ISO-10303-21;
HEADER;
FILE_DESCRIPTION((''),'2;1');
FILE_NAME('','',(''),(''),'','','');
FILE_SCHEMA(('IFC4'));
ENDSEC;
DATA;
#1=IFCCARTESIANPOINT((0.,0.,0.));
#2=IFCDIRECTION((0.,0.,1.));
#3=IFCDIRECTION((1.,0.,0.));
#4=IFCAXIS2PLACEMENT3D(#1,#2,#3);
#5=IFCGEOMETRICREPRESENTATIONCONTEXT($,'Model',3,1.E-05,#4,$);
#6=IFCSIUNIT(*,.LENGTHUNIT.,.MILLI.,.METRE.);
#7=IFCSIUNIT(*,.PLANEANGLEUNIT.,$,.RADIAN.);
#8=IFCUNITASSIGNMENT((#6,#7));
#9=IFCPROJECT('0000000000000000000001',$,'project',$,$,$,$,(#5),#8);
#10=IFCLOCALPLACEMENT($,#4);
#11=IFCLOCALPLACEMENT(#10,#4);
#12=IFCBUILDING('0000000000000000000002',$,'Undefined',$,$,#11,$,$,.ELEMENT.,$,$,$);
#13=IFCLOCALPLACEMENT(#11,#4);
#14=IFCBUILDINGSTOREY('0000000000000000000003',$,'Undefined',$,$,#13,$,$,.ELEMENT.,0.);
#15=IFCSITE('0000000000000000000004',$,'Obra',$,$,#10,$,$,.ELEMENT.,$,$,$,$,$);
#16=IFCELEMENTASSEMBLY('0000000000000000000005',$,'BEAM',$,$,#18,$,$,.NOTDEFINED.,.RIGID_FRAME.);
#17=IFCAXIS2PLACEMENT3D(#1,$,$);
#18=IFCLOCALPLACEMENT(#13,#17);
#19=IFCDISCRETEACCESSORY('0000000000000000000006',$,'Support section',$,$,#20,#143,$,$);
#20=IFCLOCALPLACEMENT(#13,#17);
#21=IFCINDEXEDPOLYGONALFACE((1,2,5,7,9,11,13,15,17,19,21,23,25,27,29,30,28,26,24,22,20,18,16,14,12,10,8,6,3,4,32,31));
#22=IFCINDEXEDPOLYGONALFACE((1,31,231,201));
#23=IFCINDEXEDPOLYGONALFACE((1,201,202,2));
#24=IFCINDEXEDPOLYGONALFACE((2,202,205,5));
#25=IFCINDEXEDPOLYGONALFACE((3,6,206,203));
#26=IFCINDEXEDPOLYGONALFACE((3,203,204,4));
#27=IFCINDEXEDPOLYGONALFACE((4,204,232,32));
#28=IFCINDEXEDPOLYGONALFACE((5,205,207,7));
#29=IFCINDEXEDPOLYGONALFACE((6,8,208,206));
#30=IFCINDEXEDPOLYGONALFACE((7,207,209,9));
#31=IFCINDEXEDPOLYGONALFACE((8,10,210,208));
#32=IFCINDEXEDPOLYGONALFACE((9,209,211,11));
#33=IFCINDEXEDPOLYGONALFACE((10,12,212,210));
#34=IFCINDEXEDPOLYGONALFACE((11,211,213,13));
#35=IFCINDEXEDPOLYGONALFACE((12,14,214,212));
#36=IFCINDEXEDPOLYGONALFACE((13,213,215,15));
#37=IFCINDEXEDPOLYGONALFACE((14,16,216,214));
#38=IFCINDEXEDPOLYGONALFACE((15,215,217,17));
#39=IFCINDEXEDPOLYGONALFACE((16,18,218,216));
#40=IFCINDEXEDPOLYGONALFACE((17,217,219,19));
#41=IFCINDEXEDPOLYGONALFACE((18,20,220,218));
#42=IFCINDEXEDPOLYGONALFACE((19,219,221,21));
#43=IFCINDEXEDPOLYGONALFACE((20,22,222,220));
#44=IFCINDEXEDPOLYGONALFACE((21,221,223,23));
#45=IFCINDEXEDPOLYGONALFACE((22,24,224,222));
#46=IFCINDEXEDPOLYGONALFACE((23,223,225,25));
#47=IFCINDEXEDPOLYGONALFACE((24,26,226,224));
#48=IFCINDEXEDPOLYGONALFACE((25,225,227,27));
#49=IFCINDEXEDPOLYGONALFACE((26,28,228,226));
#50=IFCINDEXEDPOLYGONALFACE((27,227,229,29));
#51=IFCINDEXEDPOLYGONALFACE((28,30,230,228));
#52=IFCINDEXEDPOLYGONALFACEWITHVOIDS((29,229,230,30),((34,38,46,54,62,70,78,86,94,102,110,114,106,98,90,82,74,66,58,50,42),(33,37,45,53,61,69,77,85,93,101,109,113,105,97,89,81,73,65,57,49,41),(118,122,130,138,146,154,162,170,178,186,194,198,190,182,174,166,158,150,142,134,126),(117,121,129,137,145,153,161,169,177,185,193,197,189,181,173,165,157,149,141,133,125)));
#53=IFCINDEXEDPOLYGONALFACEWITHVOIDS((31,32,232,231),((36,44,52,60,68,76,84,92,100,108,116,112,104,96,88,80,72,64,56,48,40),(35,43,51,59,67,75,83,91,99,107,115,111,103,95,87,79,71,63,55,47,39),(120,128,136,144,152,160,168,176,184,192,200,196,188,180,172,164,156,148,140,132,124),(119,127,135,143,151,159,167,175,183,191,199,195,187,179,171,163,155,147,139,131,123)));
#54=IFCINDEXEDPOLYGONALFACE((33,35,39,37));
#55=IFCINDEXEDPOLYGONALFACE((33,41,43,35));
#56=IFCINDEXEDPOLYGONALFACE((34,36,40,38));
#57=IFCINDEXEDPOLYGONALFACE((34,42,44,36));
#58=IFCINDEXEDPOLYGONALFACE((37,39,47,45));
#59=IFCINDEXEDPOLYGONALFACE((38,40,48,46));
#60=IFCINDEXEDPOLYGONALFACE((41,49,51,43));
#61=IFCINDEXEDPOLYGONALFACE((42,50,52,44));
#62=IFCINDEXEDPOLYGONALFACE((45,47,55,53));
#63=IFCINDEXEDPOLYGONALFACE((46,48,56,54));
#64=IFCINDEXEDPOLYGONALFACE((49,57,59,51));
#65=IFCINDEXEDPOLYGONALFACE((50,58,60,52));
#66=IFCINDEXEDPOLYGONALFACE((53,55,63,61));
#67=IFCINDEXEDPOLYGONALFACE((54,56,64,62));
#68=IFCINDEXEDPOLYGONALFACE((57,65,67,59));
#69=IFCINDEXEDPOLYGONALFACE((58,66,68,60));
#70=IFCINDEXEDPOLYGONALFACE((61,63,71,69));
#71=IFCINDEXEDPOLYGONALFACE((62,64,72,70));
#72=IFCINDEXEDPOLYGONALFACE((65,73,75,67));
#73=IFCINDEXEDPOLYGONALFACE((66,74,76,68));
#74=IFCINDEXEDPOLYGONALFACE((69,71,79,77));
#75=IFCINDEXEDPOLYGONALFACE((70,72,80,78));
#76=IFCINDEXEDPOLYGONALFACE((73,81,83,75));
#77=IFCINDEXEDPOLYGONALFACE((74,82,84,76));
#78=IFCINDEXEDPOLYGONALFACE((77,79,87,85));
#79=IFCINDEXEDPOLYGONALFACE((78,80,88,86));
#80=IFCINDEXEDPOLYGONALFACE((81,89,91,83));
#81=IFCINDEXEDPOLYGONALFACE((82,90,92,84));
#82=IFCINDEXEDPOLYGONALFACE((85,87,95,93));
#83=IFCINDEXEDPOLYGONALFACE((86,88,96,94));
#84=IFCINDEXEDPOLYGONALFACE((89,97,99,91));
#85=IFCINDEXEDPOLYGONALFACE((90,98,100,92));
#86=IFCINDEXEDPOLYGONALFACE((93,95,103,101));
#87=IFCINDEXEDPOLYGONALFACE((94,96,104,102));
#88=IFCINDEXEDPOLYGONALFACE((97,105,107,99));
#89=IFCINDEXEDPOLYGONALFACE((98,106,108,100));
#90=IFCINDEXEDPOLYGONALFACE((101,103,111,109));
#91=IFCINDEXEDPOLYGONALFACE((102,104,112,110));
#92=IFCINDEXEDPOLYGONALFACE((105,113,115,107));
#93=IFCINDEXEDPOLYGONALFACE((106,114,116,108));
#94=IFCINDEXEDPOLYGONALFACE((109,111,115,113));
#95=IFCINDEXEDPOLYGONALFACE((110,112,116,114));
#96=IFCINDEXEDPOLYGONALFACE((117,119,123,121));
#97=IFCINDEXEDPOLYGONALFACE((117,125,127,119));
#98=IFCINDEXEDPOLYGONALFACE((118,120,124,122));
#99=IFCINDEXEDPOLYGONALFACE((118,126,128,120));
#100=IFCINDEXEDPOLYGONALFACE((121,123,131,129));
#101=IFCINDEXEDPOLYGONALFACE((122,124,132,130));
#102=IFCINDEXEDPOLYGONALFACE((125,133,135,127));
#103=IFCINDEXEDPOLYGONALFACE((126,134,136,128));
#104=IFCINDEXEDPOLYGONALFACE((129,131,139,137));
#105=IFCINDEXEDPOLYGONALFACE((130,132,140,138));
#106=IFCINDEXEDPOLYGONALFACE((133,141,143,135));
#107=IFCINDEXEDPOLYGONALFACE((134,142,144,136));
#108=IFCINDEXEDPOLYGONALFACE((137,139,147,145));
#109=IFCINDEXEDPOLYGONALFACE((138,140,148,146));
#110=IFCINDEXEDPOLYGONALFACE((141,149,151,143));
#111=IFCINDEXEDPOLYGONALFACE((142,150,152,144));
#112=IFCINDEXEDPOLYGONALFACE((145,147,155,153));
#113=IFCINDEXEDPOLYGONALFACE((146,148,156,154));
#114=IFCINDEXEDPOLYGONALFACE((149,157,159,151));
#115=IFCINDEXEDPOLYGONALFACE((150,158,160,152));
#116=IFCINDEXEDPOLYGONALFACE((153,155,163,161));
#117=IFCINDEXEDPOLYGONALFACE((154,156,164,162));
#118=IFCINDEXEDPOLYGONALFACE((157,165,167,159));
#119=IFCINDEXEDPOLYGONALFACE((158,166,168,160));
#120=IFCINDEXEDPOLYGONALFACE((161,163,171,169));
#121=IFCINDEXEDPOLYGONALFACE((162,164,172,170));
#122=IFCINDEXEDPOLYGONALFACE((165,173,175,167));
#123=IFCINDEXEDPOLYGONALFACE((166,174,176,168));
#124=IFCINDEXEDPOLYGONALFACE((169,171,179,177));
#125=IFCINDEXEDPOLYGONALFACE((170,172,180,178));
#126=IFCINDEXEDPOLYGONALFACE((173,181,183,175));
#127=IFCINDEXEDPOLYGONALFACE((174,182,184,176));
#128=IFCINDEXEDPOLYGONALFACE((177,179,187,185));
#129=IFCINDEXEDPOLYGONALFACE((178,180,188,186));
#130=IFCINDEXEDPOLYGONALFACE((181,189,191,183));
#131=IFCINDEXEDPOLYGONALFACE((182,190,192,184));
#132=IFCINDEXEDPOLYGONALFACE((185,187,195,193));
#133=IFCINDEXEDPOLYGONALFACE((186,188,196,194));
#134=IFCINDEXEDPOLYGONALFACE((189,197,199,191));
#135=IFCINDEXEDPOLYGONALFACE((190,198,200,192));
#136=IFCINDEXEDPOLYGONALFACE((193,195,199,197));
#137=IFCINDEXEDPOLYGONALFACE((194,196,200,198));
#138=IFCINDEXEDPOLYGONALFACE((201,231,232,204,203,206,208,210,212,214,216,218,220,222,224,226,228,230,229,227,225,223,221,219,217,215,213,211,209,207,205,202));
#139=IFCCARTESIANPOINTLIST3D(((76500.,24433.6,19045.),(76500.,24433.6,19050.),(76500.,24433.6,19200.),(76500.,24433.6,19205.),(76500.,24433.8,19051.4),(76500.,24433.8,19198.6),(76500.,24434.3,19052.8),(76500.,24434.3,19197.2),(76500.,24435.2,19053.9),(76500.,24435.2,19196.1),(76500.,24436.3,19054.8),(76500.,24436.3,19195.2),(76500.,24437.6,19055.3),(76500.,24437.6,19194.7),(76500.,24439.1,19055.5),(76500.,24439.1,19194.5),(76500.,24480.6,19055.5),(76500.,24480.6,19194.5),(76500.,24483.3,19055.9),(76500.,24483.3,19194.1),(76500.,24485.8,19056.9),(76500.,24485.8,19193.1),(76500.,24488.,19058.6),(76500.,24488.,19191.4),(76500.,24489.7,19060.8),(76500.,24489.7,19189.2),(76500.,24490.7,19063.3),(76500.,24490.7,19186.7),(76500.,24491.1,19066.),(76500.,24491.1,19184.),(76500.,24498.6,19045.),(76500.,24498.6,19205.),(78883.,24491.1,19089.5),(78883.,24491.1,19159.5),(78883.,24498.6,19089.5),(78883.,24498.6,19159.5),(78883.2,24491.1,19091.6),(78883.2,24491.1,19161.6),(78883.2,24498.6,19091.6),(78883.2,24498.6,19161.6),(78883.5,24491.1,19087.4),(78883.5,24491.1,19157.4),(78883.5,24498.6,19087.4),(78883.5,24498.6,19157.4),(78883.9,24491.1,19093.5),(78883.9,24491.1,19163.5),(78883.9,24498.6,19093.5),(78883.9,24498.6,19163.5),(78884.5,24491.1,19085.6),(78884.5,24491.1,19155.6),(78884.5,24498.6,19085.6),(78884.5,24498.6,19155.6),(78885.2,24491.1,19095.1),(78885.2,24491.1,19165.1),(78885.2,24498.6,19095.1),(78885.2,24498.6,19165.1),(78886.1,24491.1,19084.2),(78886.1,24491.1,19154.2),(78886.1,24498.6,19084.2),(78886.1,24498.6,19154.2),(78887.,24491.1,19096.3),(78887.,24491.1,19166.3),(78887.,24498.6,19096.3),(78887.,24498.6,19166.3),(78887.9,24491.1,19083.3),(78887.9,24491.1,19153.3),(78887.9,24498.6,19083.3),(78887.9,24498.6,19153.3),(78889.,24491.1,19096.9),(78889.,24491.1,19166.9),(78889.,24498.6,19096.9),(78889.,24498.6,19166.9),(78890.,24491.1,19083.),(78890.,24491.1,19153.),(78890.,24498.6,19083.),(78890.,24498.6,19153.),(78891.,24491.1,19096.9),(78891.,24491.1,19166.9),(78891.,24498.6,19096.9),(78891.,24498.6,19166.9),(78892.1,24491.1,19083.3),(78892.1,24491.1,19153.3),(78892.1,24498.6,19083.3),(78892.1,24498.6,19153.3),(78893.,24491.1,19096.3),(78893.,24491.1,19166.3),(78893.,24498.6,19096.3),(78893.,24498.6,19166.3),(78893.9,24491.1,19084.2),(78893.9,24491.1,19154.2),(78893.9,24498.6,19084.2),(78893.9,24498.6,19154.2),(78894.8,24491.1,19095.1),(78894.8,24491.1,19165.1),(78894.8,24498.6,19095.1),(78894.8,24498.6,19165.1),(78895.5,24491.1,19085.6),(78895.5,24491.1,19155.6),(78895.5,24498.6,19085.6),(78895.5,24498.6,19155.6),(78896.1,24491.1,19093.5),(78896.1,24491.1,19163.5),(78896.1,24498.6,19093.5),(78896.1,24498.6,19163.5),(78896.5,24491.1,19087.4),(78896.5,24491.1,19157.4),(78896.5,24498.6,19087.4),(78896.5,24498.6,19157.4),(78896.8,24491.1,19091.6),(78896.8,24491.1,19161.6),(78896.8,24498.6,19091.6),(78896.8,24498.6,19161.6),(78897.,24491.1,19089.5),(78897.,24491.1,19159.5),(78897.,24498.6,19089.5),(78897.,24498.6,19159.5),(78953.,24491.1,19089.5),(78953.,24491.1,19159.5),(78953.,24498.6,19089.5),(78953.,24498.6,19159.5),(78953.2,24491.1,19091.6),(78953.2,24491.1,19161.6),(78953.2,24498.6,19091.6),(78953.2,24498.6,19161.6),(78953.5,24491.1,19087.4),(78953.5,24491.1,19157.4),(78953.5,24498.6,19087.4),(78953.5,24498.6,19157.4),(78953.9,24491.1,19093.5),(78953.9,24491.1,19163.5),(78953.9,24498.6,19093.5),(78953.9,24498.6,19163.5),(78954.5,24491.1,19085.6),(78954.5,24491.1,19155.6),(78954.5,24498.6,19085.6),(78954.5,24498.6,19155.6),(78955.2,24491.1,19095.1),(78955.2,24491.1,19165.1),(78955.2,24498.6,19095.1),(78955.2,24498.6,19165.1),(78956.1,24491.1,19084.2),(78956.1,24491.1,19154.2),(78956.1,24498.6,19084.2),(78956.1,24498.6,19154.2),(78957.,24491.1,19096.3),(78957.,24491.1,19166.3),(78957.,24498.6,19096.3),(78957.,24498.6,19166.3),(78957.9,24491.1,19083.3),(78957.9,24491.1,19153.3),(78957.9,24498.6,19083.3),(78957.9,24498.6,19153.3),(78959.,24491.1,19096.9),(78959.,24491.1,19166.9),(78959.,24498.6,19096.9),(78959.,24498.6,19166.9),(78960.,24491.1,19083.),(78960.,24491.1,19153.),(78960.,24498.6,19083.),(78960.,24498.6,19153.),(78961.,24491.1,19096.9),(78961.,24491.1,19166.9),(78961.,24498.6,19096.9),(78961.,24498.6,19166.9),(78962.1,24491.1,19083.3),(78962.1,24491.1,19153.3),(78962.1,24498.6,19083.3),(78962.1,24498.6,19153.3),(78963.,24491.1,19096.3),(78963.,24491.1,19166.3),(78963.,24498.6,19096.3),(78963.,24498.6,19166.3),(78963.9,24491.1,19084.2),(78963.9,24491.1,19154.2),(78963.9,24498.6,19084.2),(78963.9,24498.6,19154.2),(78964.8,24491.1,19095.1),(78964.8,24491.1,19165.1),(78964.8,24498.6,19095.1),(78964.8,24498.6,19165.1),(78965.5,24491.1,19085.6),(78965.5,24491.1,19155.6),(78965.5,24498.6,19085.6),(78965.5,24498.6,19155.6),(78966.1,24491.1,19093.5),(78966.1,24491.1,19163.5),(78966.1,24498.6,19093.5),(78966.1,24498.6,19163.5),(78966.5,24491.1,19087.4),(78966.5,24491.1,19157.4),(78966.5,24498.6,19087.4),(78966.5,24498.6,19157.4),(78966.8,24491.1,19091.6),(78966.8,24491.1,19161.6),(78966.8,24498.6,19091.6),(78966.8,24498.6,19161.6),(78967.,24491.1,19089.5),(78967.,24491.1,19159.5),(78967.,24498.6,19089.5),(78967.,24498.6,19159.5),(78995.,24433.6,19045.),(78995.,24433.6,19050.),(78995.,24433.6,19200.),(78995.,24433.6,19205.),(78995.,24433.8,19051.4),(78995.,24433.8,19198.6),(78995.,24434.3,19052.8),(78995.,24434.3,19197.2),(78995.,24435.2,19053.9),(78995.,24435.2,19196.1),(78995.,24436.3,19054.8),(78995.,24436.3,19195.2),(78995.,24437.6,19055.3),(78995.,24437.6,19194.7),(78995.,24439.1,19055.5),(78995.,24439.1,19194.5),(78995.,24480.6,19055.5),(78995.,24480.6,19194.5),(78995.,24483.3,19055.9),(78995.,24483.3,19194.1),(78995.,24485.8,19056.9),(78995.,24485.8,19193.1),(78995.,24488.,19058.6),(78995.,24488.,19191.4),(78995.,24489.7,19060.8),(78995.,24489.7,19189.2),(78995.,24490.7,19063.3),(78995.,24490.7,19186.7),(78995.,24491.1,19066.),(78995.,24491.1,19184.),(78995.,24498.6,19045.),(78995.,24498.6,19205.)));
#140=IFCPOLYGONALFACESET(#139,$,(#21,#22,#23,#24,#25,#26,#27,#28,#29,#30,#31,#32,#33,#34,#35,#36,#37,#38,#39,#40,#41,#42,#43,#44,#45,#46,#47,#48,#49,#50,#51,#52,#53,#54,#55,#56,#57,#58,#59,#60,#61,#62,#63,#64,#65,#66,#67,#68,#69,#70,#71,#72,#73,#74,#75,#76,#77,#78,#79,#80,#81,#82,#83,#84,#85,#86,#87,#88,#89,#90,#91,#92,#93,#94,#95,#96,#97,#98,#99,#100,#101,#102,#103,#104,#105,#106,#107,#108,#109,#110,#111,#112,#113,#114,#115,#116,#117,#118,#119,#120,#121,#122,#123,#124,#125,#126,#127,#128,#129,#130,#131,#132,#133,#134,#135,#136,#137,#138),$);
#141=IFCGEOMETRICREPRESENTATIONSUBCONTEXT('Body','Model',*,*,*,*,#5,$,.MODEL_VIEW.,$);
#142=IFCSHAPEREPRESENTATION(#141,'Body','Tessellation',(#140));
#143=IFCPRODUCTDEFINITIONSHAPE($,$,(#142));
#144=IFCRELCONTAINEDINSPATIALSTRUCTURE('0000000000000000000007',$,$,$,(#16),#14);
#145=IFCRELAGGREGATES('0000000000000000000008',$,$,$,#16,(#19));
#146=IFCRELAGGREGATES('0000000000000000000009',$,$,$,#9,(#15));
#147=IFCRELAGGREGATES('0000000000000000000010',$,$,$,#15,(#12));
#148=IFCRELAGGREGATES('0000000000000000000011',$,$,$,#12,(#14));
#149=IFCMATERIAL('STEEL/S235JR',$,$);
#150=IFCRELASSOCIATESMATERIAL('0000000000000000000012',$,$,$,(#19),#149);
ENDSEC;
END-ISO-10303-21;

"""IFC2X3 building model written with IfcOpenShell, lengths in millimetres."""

from ifc_helpers import new_model, si_unit, frame, origin_with_axes, origin_2d_with_axis, place, context, subcontext, project, spatial, circle, u_section, extrude, clip, halfspace, source, transform, mapped, material, element, aggregate, save


model = new_model("IFC2X3")

# Units and contexts
model_context = context("Model", 3, precision=1e-05, world=origin_with_axes())
body_context = subcontext(model_context, "Body", "Model", "MODEL_VIEW")
ifc_project = project(units=[si_unit("LENGTHUNIT", "METRE", prefix="MILLI"), si_unit("PLANEANGLEUNIT", "RADIAN")], contexts=[model_context])

# Site, building, storey
site_placement = place(None, origin_with_axes())
site = spatial("IfcSite", under=ifc_project, at=site_placement, Name="Obra", CompositionType="ELEMENT")
building_placement = place(site_placement, origin_with_axes())
building = spatial("IfcBuilding", under=site, at=building_placement, Name="Undefined", CompositionType="ELEMENT")
storey_placement = place(building_placement, origin_with_axes())
storey = spatial("IfcBuildingStorey", under=building, at=storey_placement, Name="Undefined", CompositionType="ELEMENT", Elevation=0.0)

# Shared definitions
ifc_material_1 = material(Name="STEEL/S235JR")

# Element assembly, discrete accessory, opening
assembly_1_placement = place(storey_placement, origin_with_axes())
assembly_1 = element("IfcElementAssembly", 1, at=assembly_1_placement, inside=storey, Name="BEAM", AssemblyPlace="NOTDEFINED", PredefinedType="RIGID_FRAME")
discrete_accessory_1_placement = place(assembly_1_placement, frame((76500.0, 24466.1, 19125.0), z_axis=(0.0, 0.0, 1.0), x_axis=(1.0, 0.0, 0.0)))
discrete_accessory_1 = element("IfcDiscreteAccessory", 2, at=discrete_accessory_1_placement, material=ifc_material_1, Name="Support section", context=body_context, shape_type="Clipping", body=[
    clip(extrude(u_section(Depth=160.0, FlangeWidth=65.0, WebThickness=7.5, FlangeThickness=10.5, FilletRadius=10.5, EdgeRadius=5.5, at=origin_2d_with_axis()), frame((2495.0, 0.0, 0.0), z_axis=(-1.0, 0.0, 0.0), x_axis=(0.0, -1.0, 0.0)), (0.0, 0.0, 1.0), 2495.0), halfspace(frame((2495.0, 0.0, 166.3), z_axis=(1.0, 0.0, 0.0), x_axis=(0.0, 1.0, 0.0)), False)),
])
shared_shape_1 = source(origin_with_axes(), body_context, "Body", "SweptSolid", [
    extrude(circle(Radius=7.0, at=origin_2d_with_axis()), frame((0.0, -3.8, 0.0), z_axis=(0.0, 1.0, 0.0), x_axis=(1.0, 0.0, 0.0)), (0.0, 0.0, 1.0), 7.7),
])
opening_1_placement = place(assembly_1_placement, frame((78960.0, 24494.8, 19160.0), z_axis=(-1.0, 0.0, 0.0), x_axis=(0.0, 0.0, -1.0)))
element("IfcOpeningElement", 3, at=opening_1_placement, cuts=discrete_accessory_1, ObjectType="Opening", context=body_context, shape_type="MappedRepresentation", body=[
    mapped(shared_shape_1, transform((0.0, 0.0, 0.0))),
    mapped(shared_shape_1, transform((0.0, 0.0, 70.0))),
    mapped(shared_shape_1, transform((70.0, 0.0, 0.0))),
    mapped(shared_shape_1, transform((70.0, 0.0, 70.0))),
])
aggregate(assembly_1, [discrete_accessory_1])

save(model, "model.ifc")
